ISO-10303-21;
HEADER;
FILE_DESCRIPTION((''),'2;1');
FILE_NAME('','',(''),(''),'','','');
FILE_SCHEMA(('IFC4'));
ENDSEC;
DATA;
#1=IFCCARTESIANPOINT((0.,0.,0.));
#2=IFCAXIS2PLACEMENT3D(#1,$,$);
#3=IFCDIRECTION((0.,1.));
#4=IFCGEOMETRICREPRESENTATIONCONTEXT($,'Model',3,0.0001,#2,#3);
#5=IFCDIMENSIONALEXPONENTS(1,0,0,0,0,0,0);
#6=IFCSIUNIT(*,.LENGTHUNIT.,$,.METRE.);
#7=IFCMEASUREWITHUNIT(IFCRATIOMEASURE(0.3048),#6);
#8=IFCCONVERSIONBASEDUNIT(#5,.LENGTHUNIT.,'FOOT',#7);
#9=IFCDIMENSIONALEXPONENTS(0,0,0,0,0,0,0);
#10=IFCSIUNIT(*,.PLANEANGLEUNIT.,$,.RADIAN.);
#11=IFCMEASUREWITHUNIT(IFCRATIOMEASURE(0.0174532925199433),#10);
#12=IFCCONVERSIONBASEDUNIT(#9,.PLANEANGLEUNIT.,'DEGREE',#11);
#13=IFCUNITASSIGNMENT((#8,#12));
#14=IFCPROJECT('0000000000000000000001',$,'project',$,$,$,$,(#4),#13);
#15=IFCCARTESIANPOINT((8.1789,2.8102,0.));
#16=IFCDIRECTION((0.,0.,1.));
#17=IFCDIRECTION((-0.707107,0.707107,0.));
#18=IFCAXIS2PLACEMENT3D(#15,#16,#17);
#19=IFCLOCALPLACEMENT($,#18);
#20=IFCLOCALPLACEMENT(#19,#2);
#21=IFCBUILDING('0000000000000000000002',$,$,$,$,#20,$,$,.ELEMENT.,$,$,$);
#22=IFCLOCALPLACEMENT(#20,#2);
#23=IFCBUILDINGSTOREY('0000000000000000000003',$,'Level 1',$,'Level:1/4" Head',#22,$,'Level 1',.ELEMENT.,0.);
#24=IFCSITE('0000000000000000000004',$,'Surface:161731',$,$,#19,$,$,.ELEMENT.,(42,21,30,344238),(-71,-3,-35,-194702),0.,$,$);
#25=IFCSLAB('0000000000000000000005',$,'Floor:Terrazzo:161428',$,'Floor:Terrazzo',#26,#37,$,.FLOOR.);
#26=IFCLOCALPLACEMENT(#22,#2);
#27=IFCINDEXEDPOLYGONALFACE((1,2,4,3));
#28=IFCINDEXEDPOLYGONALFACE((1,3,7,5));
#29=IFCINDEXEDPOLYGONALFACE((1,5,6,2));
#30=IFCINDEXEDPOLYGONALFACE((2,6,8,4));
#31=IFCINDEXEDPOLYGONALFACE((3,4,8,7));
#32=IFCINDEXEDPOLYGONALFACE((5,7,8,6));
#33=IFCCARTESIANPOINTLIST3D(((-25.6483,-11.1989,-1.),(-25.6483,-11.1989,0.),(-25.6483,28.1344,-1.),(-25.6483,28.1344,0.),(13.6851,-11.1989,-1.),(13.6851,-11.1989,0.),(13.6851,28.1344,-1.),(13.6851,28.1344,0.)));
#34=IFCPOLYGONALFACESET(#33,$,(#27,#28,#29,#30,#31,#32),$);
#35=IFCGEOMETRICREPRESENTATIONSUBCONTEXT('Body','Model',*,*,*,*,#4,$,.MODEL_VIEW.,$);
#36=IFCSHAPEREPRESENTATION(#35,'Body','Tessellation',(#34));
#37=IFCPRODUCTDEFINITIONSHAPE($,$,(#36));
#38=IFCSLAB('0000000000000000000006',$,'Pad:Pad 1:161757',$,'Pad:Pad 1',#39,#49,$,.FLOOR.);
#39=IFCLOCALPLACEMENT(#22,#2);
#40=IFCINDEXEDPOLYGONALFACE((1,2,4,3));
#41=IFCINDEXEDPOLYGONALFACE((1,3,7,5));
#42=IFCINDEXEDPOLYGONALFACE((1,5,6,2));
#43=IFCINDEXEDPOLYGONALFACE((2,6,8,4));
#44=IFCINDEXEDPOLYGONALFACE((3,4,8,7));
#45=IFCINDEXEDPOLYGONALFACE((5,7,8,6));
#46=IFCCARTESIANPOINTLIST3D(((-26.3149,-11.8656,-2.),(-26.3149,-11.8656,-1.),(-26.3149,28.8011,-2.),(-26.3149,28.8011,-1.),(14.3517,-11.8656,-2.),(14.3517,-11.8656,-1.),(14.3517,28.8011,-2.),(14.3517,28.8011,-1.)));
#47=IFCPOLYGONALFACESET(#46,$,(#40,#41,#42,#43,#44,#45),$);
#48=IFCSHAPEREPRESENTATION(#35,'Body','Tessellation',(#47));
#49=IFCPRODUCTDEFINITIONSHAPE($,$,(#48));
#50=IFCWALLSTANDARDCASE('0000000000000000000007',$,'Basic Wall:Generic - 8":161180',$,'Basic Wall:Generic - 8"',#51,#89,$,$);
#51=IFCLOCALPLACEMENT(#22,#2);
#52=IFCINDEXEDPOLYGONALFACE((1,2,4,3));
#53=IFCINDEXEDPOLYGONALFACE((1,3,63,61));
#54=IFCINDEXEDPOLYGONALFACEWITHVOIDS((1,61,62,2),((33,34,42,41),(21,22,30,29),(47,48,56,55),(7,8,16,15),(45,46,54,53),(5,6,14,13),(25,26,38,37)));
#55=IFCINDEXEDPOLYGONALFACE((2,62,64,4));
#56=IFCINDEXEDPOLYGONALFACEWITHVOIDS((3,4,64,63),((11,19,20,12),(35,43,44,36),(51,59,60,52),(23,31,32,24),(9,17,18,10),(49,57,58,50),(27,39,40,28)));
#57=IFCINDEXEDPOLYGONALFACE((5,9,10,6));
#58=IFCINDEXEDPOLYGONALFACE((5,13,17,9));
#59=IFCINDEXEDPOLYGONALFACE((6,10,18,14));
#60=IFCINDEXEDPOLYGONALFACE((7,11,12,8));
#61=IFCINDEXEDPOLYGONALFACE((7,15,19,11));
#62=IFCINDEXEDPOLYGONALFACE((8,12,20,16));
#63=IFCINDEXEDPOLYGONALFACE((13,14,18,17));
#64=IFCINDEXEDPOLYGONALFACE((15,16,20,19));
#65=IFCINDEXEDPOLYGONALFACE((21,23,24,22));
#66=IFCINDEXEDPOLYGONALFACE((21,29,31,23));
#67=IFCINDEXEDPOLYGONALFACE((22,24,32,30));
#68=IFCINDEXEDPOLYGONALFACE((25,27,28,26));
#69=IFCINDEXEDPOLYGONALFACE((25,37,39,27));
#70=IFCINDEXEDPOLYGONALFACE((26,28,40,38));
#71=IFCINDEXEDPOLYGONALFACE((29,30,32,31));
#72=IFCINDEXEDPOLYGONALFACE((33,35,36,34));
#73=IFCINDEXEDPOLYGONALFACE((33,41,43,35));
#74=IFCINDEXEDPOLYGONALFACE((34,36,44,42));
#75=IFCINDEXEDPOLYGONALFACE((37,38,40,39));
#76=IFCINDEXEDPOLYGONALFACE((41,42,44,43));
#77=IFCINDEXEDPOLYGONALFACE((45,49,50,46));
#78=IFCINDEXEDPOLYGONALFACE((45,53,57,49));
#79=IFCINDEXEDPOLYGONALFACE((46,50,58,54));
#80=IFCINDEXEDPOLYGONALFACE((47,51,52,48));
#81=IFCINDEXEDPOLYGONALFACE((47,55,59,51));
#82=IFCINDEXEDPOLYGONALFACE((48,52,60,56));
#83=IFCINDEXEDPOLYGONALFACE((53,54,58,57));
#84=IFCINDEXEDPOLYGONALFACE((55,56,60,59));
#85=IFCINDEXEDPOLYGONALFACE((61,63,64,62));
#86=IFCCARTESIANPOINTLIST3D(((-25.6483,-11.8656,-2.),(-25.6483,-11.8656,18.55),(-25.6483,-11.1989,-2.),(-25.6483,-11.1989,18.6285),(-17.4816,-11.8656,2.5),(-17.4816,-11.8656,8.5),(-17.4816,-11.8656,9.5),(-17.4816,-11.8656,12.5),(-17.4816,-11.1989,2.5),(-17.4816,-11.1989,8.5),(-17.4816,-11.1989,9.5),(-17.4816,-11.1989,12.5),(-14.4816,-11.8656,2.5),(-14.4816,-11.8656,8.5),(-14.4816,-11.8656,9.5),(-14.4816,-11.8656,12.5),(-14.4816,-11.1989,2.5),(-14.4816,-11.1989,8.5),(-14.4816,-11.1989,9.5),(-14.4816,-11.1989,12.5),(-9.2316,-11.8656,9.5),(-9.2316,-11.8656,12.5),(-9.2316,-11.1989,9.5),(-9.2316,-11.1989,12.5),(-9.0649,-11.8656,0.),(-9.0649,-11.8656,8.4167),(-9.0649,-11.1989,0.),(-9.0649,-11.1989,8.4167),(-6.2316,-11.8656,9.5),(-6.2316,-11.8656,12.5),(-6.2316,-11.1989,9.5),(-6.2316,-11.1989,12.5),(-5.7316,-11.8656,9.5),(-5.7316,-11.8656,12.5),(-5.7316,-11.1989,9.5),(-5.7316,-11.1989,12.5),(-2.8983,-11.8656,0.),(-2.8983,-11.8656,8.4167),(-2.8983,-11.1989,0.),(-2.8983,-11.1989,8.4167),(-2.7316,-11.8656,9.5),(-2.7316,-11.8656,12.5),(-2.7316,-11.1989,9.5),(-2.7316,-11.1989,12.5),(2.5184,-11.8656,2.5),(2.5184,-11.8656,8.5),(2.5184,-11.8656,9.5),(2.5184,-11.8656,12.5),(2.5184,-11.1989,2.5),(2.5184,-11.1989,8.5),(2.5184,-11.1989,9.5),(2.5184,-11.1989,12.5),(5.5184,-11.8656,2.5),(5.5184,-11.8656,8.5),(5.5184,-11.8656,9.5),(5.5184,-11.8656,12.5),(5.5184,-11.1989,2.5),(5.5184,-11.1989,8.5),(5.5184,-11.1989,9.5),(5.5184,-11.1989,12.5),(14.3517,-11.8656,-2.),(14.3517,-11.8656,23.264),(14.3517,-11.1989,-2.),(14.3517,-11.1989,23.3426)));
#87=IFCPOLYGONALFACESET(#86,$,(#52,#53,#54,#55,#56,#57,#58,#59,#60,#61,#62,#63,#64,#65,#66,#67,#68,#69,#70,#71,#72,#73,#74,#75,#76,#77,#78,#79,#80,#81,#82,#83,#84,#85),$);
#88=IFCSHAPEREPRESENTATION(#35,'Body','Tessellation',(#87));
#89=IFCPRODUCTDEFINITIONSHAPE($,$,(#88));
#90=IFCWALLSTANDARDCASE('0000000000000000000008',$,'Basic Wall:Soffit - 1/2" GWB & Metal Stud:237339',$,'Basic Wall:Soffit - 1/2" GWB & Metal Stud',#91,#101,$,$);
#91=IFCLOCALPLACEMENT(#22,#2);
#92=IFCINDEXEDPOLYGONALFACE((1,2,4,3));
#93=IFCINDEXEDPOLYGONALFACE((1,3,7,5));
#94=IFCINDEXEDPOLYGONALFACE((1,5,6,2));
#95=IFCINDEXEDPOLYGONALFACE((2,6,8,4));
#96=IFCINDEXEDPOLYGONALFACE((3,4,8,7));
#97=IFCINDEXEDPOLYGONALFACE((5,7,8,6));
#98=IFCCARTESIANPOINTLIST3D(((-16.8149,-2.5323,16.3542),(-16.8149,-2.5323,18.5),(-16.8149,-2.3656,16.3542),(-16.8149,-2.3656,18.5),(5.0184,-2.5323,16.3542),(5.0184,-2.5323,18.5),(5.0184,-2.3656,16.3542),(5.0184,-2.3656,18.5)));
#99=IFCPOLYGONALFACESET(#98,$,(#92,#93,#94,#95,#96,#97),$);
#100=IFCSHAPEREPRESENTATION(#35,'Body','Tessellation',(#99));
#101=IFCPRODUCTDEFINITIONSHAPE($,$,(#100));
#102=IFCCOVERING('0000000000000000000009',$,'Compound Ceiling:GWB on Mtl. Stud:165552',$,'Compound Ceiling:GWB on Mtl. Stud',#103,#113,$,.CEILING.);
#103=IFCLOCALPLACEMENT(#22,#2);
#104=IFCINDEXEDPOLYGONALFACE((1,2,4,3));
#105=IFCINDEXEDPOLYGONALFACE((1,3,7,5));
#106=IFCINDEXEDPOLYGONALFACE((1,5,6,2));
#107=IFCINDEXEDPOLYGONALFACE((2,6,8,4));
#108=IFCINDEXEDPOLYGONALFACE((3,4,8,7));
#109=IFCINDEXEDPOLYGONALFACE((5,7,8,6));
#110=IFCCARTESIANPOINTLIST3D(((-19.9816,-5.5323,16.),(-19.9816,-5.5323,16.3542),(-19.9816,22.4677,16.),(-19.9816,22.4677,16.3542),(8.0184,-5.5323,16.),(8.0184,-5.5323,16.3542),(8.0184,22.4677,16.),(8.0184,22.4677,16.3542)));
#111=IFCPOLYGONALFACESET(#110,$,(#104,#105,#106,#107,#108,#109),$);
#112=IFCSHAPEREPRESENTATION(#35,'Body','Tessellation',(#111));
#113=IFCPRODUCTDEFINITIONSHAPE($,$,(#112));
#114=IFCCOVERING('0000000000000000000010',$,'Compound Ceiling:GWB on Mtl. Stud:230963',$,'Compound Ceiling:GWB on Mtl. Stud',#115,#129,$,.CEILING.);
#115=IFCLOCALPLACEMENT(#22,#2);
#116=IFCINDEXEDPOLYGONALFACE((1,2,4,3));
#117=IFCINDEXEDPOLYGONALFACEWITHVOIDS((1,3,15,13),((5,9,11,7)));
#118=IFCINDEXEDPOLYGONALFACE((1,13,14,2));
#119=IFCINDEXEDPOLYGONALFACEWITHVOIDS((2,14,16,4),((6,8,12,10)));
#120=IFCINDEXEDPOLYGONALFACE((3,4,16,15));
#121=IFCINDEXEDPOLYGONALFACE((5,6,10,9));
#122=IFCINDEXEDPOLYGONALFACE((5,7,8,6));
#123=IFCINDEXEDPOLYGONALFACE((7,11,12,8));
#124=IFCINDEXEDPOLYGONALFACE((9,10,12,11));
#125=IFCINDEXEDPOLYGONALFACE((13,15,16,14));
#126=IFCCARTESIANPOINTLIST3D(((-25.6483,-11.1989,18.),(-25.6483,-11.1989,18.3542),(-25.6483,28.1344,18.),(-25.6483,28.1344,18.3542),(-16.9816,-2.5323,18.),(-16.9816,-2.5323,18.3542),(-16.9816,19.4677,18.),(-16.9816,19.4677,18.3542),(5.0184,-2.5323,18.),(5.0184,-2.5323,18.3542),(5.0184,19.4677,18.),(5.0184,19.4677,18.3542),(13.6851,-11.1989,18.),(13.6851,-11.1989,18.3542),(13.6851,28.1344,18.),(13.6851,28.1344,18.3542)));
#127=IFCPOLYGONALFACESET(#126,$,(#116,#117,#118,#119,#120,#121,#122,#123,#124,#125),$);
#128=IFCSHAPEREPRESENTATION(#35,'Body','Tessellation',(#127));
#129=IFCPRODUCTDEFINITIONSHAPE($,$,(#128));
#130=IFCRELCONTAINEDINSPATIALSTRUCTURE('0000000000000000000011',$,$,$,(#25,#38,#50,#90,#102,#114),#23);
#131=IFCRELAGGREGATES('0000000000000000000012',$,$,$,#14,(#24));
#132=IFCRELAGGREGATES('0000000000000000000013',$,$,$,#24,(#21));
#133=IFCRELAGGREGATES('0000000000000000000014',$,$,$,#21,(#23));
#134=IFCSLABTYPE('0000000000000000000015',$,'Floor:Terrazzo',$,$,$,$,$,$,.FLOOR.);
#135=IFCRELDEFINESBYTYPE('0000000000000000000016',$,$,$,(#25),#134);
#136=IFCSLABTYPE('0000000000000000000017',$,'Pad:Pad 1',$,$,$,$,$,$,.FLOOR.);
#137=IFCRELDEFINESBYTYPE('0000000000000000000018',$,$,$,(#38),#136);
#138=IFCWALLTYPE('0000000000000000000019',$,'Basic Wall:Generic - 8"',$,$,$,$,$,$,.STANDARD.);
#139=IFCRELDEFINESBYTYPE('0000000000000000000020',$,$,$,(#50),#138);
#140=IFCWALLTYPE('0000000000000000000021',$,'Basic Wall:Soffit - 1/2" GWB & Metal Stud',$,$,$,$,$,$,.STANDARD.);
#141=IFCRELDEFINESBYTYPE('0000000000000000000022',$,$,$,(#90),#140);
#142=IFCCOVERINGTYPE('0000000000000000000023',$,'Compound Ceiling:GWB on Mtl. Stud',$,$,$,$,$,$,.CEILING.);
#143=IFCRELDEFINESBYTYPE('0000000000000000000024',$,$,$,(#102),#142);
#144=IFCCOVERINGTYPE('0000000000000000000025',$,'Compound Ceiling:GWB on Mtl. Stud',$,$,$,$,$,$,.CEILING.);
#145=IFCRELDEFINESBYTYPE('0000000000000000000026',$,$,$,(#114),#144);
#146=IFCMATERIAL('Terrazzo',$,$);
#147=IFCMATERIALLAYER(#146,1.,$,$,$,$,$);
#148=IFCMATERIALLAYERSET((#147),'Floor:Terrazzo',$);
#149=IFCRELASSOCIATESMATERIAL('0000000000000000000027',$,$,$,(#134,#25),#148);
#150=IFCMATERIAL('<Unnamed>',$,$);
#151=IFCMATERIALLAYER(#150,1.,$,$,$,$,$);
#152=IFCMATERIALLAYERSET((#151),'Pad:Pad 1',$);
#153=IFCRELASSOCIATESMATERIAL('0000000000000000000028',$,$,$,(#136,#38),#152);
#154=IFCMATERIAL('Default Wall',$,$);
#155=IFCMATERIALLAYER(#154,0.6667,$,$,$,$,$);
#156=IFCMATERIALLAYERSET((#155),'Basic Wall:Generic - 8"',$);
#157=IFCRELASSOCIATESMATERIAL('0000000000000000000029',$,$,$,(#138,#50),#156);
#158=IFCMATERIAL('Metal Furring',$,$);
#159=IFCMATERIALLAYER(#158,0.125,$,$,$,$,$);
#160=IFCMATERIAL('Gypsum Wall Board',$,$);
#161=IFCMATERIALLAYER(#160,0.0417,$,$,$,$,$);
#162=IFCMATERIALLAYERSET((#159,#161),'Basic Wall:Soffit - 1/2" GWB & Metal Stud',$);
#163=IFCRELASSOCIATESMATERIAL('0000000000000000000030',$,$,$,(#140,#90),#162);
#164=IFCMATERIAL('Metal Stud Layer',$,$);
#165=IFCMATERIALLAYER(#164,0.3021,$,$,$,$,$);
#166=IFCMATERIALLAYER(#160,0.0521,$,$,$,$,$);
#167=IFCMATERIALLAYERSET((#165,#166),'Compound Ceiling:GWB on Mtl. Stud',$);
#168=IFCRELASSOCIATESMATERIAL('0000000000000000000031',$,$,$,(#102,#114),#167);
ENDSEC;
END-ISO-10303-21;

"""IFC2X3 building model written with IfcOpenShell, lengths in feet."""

from ifc_helpers import new_model, entity, si_unit, converted_unit, direction, frame, frame_2d, origin, origin_2d_with_axis, place, context, subcontext, project, spatial, polyline, rectangle, outline, extrude, clip, bounded_halfspace, material, layer, layer_set, layer_usage, type_object, element, save


model = new_model("IFC2X3")

# Units and contexts
model_context = context("Model", 3, precision=0.0001, world=origin(), true_north=direction((0.0, 1.0)))
body_context = subcontext(model_context, "Body", "Model", "MODEL_VIEW")
ifc_project = project(units=[converted_unit("LENGTHUNIT", "FOOT", entity("IfcRatioMeasure", 0.3048), si_unit("LENGTHUNIT", "METRE"), dimensions=[1, 0, 0, 0, 0, 0, 0]), converted_unit("PLANEANGLEUNIT", "DEGREE", entity("IfcRatioMeasure", 0.0174532925199433), si_unit("PLANEANGLEUNIT", "RADIAN"), dimensions=[0, 0, 0, 0, 0, 0, 0])], contexts=[model_context])

# Site, building, storey
site_placement = place(None, frame((8.1789, 2.8102, 0.0), z_axis=(0.0, 0.0, 1.0), x_axis=(-0.707107, 0.707107, 0.0)))
site = spatial("IfcSite", under=ifc_project, at=site_placement, Name="Surface:161731", CompositionType="ELEMENT", RefLatitude=(42, 21, 30, 344238), RefLongitude=(-71, -3, -35, -194702), RefElevation=0.0)
building_placement = place(site_placement, origin())
building = spatial("IfcBuilding", under=site, at=building_placement, CompositionType="ELEMENT")
storey_placement = place(building_placement, origin())
storey = spatial("IfcBuildingStorey", under=building, at=storey_placement, Name="Level 1", ObjectType="Level:1/4\" Head", LongName="Level 1", CompositionType="ELEMENT", Elevation=0.0)

# Slabs
ifc_material_1 = material(Name="Terrazzo")
ifc_layer_1 = layer(ifc_material_1, 1.0)
ifc_layer_set_1 = layer_set([ifc_layer_1], Name="Floor:Terrazzo")
ifc_layer_usage_1 = layer_usage(ifc_layer_set_1, "AXIS3", "POSITIVE", 0.0)
slab_type_1 = type_object("IfcSlabType", Name="Floor:Terrazzo", PredefinedType="FLOOR", material=ifc_layer_set_1)
slab_1_placement = place(storey_placement, origin())
element("IfcSlab", 1, at=slab_1_placement, inside=storey, type_object=slab_type_1, material=ifc_layer_usage_1, Name="Floor:Terrazzo:161428", ObjectType="Floor:Terrazzo", PredefinedType="FLOOR", context=body_context, shape_type="SweptSolid", body=[
    extrude(rectangle(XDim=39.3333, YDim=39.3333, at=frame_2d((0.0, 0.0), x_axis=(1.0, 0.0))), frame((-5.9816, 8.4677, 0.0), z_axis=(0.0, 0.0, -1.0), x_axis=(0.0, 1.0, 0.0)), (0.0, 0.0, 1.0), 1.0),
])
ifc_material_2 = material(Name="<Unnamed>")
ifc_layer_2 = layer(ifc_material_2, 1.0)
ifc_layer_set_2 = layer_set([ifc_layer_2], Name="Pad:Pad 1")
ifc_layer_usage_2 = layer_usage(ifc_layer_set_2, "AXIS3", "POSITIVE", 0.0)
slab_type_2 = type_object("IfcSlabType", Name="Pad:Pad 1", PredefinedType="FLOOR", material=ifc_layer_set_2)
slab_2_placement = place(storey_placement, origin())
element("IfcSlab", 2, at=slab_2_placement, inside=storey, type_object=slab_type_2, material=ifc_layer_usage_2, Name="Pad:Pad 1:161757", ObjectType="Pad:Pad 1", PredefinedType="FLOOR", context=body_context, shape_type="SweptSolid", body=[
    extrude(rectangle(XDim=40.6667, YDim=40.6667, at=frame_2d((0.0, 0.0), x_axis=(1.0, 0.0))), frame((-5.9816, 8.4677, -2.0), z_axis=(0.0, 0.0, 1.0), x_axis=(-1.0, 0.0, 0.0)), (0.0, 0.0, 1.0), 1.0),
])

# Wall, openings
ifc_material_3 = material(Name="Default Wall")
ifc_layer_3 = layer(ifc_material_3, 0.6667)
ifc_layer_set_3 = layer_set([ifc_layer_3], Name="Basic Wall:Generic - 8\"")
ifc_layer_usage_3 = layer_usage(ifc_layer_set_3, "AXIS2", "NEGATIVE", 0.3333)
wall_type_1 = type_object("IfcWallType", Name="Basic Wall:Generic - 8\"", PredefinedType="STANDARD", material=ifc_layer_set_3)
wall_1_placement = place(storey_placement, frame((14.3517, -11.5323, -2.0), z_axis=(0.0, 0.0, 1.0), x_axis=(-1.0, 0.0, 0.0)))
wall_1 = element("IfcWallStandardCase", 3, at=wall_1_placement, inside=storey, type_object=wall_type_1, material=ifc_layer_usage_3, Name="Basic Wall:Generic - 8\":161180", ObjectType="Basic Wall:Generic - 8\"", context=body_context, shape_type="Clipping", body=[
    clip(extrude(rectangle(XDim=40.0, YDim=0.6667, at=frame_2d((20.0, 0.0), x_axis=(-1.0, 0.0))), origin(), (0.0, 0.0, 1.0), 25.3426), bounded_halfspace(frame((0.0, -0.3333, 25.3426), z_axis=(0.116248, 0.116248, 0.986394), x_axis=(-0.707107, 0.707107, 0.0)), False, frame((0.0, -0.3333, 25.3426)), polyline([(0.0, 0.0), (0.6667, 0.0), (40.0, 0.0), (40.0, 0.6667), (0.0, 0.6667), (0.0, 0.0)]))),
])
opening_1_placement = place(wall_1_placement, frame((23.4167, 0.3333, 2.0)))
element("IfcOpeningElement", 4, at=opening_1_placement, cuts=wall_1, ObjectType="Opening", context=body_context, shape_type="SweptSolid", body=[
    extrude(rectangle(XDim=8.4167, YDim=6.1667, at=frame_2d((4.2083, 3.0833), x_axis=(1.0, 0.0))), frame((0.0, 0.0, 0.0), z_axis=(0.0, -1.0, 0.0), x_axis=(0.0, 0.0, 1.0)), (0.0, 0.0, 1.0), 0.6667),
])
opening_2_placement = place(wall_1_placement, frame((8.8333, -0.3333, 4.5)))
element("IfcOpeningElement", 5, at=opening_2_placement, cuts=wall_1, ObjectType="Opening", context=body_context, shape_type="SweptSolid", body=[
    extrude(rectangle(XDim=6.0, YDim=3.0, at=frame_2d((3.0, 1.5), x_axis=(-1.0, 0.0))), frame((0.0, 0.0, 0.0), z_axis=(0.0, 1.0, 0.0), x_axis=(0.0, 0.0, 1.0)), (0.0, 0.0, 1.0), 0.6667),
])
opening_3_placement = place(wall_1_placement, frame((28.8333, -0.3333, 4.5)))
element("IfcOpeningElement", 6, at=opening_3_placement, cuts=wall_1, ObjectType="Opening", context=body_context, shape_type="SweptSolid", body=[
    extrude(rectangle(XDim=6.0, YDim=3.0, at=frame_2d((3.0, 1.5), x_axis=(-1.0, 0.0))), frame((0.0, 0.0, 0.0), z_axis=(0.0, 1.0, 0.0), x_axis=(0.0, 0.0, 1.0)), (0.0, 0.0, 1.0), 0.6667),
])
opening_4_placement = place(wall_1_placement, frame((8.8333, -0.3333, 11.5)))
element("IfcOpeningElement", 7, at=opening_4_placement, cuts=wall_1, ObjectType="Opening", context=body_context, shape_type="SweptSolid", body=[
    extrude(rectangle(XDim=3.0, YDim=3.0, at=frame_2d((1.5, 1.5), x_axis=(-1.0, 0.0))), frame((0.0, 0.0, 0.0), z_axis=(0.0, 1.0, 0.0), x_axis=(0.0, 0.0, 1.0)), (0.0, 0.0, 1.0), 0.6667),
])
opening_5_placement = place(wall_1_placement, frame((28.8333, -0.3333, 11.5)))
element("IfcOpeningElement", 8, at=opening_5_placement, cuts=wall_1, ObjectType="Opening", context=body_context, shape_type="SweptSolid", body=[
    extrude(rectangle(XDim=3.0, YDim=3.0, at=frame_2d((1.5, 1.5), x_axis=(-1.0, 0.0))), frame((0.0, 0.0, 0.0), z_axis=(0.0, 1.0, 0.0), x_axis=(0.0, 0.0, 1.0)), (0.0, 0.0, 1.0), 0.6667),
])
opening_6_placement = place(wall_1_placement, frame((20.5833, -0.3333, 11.5)))
element("IfcOpeningElement", 9, at=opening_6_placement, cuts=wall_1, ObjectType="Opening", context=body_context, shape_type="SweptSolid", body=[
    extrude(rectangle(XDim=3.0, YDim=3.0, at=frame_2d((1.5, 1.5), x_axis=(-1.0, 0.0))), frame((0.0, 0.0, 0.0), z_axis=(0.0, 1.0, 0.0), x_axis=(0.0, 0.0, 1.0)), (0.0, 0.0, 1.0), 0.6667),
])
opening_7_placement = place(wall_1_placement, frame((17.0833, -0.3333, 11.5)))
element("IfcOpeningElement", 10, at=opening_7_placement, cuts=wall_1, ObjectType="Opening", context=body_context, shape_type="SweptSolid", body=[
    extrude(rectangle(XDim=3.0, YDim=3.0, at=frame_2d((1.5, 1.5), x_axis=(-1.0, 0.0))), frame((0.0, 0.0, 0.0), z_axis=(0.0, 1.0, 0.0), x_axis=(0.0, 0.0, 1.0)), (0.0, 0.0, 1.0), 0.6667),
])

# Wall
ifc_material_4 = material(Name="Metal Furring")
ifc_layer_4 = layer(ifc_material_4, 0.125)
ifc_material_5 = material(Name="Gypsum Wall Board")
ifc_layer_5 = layer(ifc_material_5, 0.0417)
ifc_layer_set_4 = layer_set([ifc_layer_4, ifc_layer_5], Name="Basic Wall:Soffit - 1/2\" GWB & Metal Stud")
ifc_layer_usage_4 = layer_usage(ifc_layer_set_4, "AXIS2", "POSITIVE", -0.0833)
wall_type_2 = type_object("IfcWallType", Name="Basic Wall:Soffit - 1/2\" GWB & Metal Stud", PredefinedType="STANDARD", material=ifc_layer_set_4)
wall_2_placement = place(storey_placement, frame((5.0184, -2.4489, 16.3542), z_axis=(0.0, 0.0, 1.0), x_axis=(-1.0, 0.0, 0.0)))
element("IfcWallStandardCase", 11, at=wall_2_placement, inside=storey, type_object=wall_type_2, material=ifc_layer_usage_4, Name="Basic Wall:Soffit - 1/2\" GWB & Metal Stud:237339", ObjectType="Basic Wall:Soffit - 1/2\" GWB & Metal Stud", context=body_context, shape_type="Clipping", body=[
    clip(extrude(rectangle(XDim=21.8333, YDim=0.1667, at=frame_2d((10.9167, 0.0), x_axis=(-1.0, 0.0))), origin(), (0.0, 0.0, 1.0), 2.1458), bounded_halfspace(frame((21.8333, -0.0833, 0.0), z_axis=(0.0, 0.0, 1.0), x_axis=(0.0, 1.0, 0.0)), True, frame((21.8333, -0.0833, 0.0)), polyline([(0.0, 0.0), (0.0, 0.1667), (-21.8333, 0.1667), (-21.8333, 0.0), (-21.6667, 0.0), (0.0, 0.0)]))),
])

# Coverings
ifc_material_6 = material(Name="Metal Stud Layer")
ifc_layer_6 = layer(ifc_material_6, 0.3021)
ifc_layer_7 = layer(ifc_material_5, 0.0521)
ifc_layer_set_5 = layer_set([ifc_layer_6, ifc_layer_7], Name="Compound Ceiling:GWB on Mtl. Stud")
ifc_layer_usage_5 = layer_usage(ifc_layer_set_5, "AXIS3", "POSITIVE", 0.0)
covering_type_1 = type_object("IfcCoveringType", Name="Compound Ceiling:GWB on Mtl. Stud", PredefinedType="CEILING")
covering_1_placement = place(storey_placement, origin())
element("IfcCovering", 12, at=covering_1_placement, inside=storey, type_object=covering_type_1, material=ifc_layer_usage_5, Name="Compound Ceiling:GWB on Mtl. Stud:165552", ObjectType="Compound Ceiling:GWB on Mtl. Stud", PredefinedType="CEILING", context=body_context, shape_type="SweptSolid", body=[
    extrude(rectangle(XDim=28.0, YDim=28.0, at=origin_2d_with_axis()), frame((-5.9816, 8.4677, 16.0), z_axis=(0.0, 0.0, 1.0), x_axis=(0.0, -1.0, 0.0)), (0.0, 0.0, 1.0), 0.3542),
])
ifc_layer_usage_6 = layer_usage(ifc_layer_set_5, "AXIS3", "POSITIVE", 0.0)
covering_type_2 = type_object("IfcCoveringType", Name="Compound Ceiling:GWB on Mtl. Stud", PredefinedType="CEILING")
covering_2_placement = place(storey_placement, origin())
element("IfcCovering", 13, at=covering_2_placement, inside=storey, type_object=covering_type_2, material=ifc_layer_usage_6, Name="Compound Ceiling:GWB on Mtl. Stud:230963", ObjectType="Compound Ceiling:GWB on Mtl. Stud", PredefinedType="CEILING", context=body_context, shape_type="SweptSolid", body=[
    extrude(outline(polyline([(-19.6667, -19.6667), (19.6667, -19.6667), (19.6667, 19.6667), (-19.6667, 19.6667), (-19.6667, -19.6667)]), holes=[polyline([(-11.0, -11.0), (-11.0, 11.0), (11.0, 11.0), (11.0, -11.0), (-11.0, -11.0)])]), frame((-5.9816, 8.4677, 18.0), z_axis=(0.0, 0.0, 1.0), x_axis=(0.0, -1.0, 0.0)), (0.0, 0.0, 1.0), 0.3542),
])

save(model, "model.ifc")
